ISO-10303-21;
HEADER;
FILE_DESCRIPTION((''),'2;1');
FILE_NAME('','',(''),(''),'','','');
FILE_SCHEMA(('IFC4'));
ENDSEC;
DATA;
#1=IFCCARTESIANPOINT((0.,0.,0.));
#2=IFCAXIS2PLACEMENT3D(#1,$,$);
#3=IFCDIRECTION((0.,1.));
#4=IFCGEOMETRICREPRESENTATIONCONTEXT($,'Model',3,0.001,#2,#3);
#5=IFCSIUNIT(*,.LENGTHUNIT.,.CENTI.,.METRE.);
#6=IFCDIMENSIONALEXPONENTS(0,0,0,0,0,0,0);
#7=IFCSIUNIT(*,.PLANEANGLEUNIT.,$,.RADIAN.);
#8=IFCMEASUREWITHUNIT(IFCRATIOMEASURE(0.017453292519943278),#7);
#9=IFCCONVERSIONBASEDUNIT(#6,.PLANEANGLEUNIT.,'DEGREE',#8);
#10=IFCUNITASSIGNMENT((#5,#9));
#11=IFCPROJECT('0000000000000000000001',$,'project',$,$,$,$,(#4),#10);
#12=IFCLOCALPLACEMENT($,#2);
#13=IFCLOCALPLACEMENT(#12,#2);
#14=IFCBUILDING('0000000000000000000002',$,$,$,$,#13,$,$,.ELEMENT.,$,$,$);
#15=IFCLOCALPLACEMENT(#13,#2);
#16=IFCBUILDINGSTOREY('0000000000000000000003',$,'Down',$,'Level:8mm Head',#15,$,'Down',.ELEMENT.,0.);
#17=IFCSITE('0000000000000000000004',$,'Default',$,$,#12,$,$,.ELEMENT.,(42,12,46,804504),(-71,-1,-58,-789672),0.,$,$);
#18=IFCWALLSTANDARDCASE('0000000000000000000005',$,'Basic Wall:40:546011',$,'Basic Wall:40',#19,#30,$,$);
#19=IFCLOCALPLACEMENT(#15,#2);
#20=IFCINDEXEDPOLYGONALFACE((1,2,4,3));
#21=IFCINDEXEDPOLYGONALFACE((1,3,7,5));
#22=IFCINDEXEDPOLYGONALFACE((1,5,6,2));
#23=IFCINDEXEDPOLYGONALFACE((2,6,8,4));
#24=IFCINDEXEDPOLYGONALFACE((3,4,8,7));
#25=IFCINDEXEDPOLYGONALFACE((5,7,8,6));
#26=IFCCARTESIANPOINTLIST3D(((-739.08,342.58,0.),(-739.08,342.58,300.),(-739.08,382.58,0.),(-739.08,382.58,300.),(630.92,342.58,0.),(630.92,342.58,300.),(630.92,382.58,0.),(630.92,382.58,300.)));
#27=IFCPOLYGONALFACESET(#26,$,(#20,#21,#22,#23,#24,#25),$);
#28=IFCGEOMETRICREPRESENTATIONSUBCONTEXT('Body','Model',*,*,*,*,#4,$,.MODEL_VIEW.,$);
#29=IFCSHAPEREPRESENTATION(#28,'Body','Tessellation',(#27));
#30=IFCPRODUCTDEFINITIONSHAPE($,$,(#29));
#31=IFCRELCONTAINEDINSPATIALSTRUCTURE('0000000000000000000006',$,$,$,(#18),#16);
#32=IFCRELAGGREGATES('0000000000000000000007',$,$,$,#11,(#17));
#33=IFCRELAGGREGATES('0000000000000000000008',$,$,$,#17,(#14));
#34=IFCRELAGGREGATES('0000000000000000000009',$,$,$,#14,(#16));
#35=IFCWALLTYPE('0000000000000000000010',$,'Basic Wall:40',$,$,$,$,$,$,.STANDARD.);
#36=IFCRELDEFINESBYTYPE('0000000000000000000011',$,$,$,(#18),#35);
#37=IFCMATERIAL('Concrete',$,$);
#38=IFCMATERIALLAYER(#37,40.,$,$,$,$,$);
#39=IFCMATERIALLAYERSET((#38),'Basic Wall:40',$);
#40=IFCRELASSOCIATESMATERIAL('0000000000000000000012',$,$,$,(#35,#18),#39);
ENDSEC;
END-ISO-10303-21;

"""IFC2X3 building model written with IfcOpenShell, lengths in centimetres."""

from ifc_helpers import new_model, entity, si_unit, converted_unit, direction, frame, frame_2d, origin, place, context, subcontext, project, spatial, rectangle, extrude, material, layer, layer_set, layer_usage, type_object, element, save


model = new_model("IFC2X3")

# Units and contexts
model_context = context("Model", 3, precision=0.001, world=origin(), true_north=direction((0.0, 1.0)))
body_context = subcontext(model_context, "Body", "Model", "MODEL_VIEW")
ifc_project = project(units=[si_unit("LENGTHUNIT", "METRE", prefix="CENTI"), converted_unit("PLANEANGLEUNIT", "DEGREE", entity("IfcRatioMeasure", 0.017453292519943278), si_unit("PLANEANGLEUNIT", "RADIAN"), dimensions=[0, 0, 0, 0, 0, 0, 0])], contexts=[model_context])

# Site, building, storey
site_placement = place(None, origin())
site = spatial("IfcSite", under=ifc_project, at=site_placement, Name="Default", CompositionType="ELEMENT", RefLatitude=(42, 12, 46, 804504), RefLongitude=(-71, -1, -58, -789672), RefElevation=0.0)
building_placement = place(site_placement, origin())
building = spatial("IfcBuilding", under=site, at=building_placement, CompositionType="ELEMENT")
storey_placement = place(building_placement, origin())
storey = spatial("IfcBuildingStorey", under=building, at=storey_placement, Name="Down", ObjectType="Level:8mm Head", LongName="Down", CompositionType="ELEMENT", Elevation=0.0)

# Shared definitions
ifc_material = material(Name="Concrete")

# Wall
ifc_layer_1 = layer(ifc_material, 40.0)
ifc_layer_set_1 = layer_set([ifc_layer_1], Name="Basic Wall:40")
ifc_layer_usage_1 = layer_usage(ifc_layer_set_1, "AXIS2", "POSITIVE", -20.0)
wall_type_1 = type_object("IfcWallType", Name="Basic Wall:40", PredefinedType="STANDARD", material=ifc_layer_set_1)
wall_1_placement = place(storey_placement, frame((-739.08, 362.58, 0.0)))
element("IfcWallStandardCase", 1, at=wall_1_placement, inside=storey, type_object=wall_type_1, material=ifc_layer_usage_1, Name="Basic Wall:40:546011", ObjectType="Basic Wall:40", context=body_context, shape_type="SweptSolid", body=[
    extrude(rectangle(XDim=1370.0, YDim=40.0, at=frame_2d((685.0, 0.0), x_axis=(-1.0, 0.0))), origin(), (0.0, 0.0, 1.0), 300.0),
])

save(model, "model.ifc")
